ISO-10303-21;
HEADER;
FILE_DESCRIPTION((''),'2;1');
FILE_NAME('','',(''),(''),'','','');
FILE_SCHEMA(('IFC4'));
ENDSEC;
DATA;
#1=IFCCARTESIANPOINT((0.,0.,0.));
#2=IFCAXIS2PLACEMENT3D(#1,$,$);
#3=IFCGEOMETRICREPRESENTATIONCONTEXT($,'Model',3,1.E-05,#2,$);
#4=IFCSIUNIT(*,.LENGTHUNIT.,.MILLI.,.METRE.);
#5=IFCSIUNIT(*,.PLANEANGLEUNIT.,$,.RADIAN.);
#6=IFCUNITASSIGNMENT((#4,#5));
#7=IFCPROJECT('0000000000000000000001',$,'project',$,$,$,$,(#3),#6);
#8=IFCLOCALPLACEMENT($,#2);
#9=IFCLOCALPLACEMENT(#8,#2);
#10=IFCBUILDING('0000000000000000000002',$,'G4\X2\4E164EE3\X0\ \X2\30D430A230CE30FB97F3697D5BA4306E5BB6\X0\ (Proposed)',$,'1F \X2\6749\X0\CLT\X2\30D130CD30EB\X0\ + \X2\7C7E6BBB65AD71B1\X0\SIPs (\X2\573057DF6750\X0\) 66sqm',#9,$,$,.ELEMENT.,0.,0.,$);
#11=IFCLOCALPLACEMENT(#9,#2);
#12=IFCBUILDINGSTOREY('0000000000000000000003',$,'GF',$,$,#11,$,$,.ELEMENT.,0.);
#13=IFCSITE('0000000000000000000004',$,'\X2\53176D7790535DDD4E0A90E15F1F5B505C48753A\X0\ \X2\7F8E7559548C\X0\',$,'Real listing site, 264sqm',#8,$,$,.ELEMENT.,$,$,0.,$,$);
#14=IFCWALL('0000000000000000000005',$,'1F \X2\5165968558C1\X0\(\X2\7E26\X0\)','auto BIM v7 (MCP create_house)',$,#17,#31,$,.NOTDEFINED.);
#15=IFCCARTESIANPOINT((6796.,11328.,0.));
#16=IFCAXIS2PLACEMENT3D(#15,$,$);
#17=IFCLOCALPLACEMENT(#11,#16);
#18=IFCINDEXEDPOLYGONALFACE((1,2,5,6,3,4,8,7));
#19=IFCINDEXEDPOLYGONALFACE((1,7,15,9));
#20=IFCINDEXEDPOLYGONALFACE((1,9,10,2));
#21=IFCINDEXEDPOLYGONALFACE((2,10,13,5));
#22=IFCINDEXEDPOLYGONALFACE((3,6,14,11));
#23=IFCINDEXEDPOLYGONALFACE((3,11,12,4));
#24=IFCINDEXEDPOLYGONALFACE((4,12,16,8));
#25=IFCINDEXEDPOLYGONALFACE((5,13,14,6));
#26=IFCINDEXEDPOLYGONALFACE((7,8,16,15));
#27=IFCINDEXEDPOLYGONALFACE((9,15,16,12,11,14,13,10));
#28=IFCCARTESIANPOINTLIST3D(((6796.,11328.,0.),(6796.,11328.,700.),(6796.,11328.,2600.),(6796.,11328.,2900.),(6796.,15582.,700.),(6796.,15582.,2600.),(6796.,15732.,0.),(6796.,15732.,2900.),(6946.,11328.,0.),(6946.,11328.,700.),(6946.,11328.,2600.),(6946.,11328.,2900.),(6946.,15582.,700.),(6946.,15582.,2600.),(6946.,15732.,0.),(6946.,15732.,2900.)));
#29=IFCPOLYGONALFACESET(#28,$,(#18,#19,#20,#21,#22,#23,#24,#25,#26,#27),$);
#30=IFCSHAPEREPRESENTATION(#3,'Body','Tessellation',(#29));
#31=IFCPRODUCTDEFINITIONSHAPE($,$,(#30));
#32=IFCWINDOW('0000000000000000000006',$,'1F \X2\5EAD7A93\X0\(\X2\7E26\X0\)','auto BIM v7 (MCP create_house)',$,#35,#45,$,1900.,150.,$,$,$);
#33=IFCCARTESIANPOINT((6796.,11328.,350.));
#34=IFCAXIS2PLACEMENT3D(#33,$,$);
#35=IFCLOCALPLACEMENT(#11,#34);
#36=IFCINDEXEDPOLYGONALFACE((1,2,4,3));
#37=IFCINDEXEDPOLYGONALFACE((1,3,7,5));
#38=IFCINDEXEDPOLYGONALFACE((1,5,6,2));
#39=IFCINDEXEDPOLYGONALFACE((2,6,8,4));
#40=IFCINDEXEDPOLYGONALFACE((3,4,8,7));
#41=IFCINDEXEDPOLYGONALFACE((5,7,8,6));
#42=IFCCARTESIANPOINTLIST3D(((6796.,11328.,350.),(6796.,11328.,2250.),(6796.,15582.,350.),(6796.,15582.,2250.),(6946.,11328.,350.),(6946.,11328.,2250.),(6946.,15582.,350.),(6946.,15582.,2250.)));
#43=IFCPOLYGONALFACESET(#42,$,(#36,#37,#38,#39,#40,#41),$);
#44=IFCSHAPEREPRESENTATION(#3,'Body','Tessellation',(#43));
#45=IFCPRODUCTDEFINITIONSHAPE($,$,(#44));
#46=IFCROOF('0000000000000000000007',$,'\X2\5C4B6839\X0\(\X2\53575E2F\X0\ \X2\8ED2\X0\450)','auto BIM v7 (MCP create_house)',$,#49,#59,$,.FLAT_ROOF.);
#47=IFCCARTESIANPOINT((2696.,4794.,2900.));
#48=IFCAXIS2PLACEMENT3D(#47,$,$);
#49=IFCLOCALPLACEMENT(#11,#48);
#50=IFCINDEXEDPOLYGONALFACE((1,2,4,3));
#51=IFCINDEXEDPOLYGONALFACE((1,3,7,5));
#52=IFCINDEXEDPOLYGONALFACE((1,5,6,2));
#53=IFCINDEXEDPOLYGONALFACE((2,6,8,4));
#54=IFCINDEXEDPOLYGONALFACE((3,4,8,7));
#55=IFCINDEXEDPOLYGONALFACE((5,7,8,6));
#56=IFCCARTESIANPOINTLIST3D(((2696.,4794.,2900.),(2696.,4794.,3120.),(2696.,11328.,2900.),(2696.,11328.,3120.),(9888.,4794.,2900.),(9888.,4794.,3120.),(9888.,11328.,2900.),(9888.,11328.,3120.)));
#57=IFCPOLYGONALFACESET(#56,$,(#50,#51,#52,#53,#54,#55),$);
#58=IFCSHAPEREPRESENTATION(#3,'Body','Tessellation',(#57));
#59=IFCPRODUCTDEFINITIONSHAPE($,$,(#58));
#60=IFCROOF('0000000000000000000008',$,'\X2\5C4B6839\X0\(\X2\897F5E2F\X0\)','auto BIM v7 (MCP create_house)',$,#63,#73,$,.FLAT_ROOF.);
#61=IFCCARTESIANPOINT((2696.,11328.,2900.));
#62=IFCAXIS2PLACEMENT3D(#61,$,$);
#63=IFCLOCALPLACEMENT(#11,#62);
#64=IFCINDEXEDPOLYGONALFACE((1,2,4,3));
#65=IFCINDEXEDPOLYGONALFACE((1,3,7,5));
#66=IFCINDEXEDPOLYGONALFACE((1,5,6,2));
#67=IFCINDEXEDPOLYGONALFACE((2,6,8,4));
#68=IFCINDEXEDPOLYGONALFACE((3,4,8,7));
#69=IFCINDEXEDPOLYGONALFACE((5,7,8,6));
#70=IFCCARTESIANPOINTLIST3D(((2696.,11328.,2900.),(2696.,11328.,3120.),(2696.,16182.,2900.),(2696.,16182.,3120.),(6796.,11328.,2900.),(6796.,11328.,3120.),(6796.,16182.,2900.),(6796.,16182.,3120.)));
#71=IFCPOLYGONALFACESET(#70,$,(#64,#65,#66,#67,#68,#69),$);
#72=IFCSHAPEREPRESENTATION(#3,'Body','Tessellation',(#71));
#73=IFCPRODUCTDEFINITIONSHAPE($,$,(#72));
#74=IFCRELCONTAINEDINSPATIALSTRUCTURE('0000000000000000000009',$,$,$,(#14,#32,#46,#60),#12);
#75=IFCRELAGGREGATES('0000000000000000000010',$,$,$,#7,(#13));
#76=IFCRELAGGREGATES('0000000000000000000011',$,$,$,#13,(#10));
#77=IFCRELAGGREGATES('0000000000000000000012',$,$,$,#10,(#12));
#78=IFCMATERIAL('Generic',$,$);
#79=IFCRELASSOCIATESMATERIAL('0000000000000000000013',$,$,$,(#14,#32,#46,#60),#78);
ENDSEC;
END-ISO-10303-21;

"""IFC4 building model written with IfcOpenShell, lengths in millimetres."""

from ifc_helpers import new_model, si_unit, frame, frame_2d, origin, place, context, project, spatial, rectangle, extrude, material, element, fill, save


model = new_model("IFC4")

# Units and contexts
model_context = context("Model", 3, precision=1e-05, world=origin())
ifc_project = project(units=[si_unit("LENGTHUNIT", "METRE", prefix="MILLI"), si_unit("PLANEANGLEUNIT", "RADIAN")], contexts=[model_context])

# Site, building, storey
site_placement = place(None, origin())
site = spatial("IfcSite", under=ifc_project, at=site_placement, Name="北海道川上郡弟子屈町 美留和", ObjectType="Real listing site, 264sqm", CompositionType="ELEMENT", RefElevation=0.0)
building_placement = place(site_placement, origin())
building = spatial("IfcBuilding", under=site, at=building_placement, Name="G4世代 ピアノ・音楽室の家 (Proposed)", ObjectType="1F 杉CLTパネル + 籾殻断熱SIPs (地域材) 66sqm", CompositionType="ELEMENT", ElevationOfRefHeight=0.0, ElevationOfTerrain=0.0)
storey_placement = place(building_placement, origin())
storey = spatial("IfcBuildingStorey", under=building, at=storey_placement, Name="GF", CompositionType="ELEMENT", Elevation=0.0)

# Shared definitions
ifc_material = material(Name="Generic")

# Wall, opening, window
wall_1_placement = place(storey_placement, frame((6796.0, 11328.0, 0.0)))
wall_1 = element("IfcWall", 1, at=wall_1_placement, inside=storey, material=ifc_material, Name="1F 入隅壁(縦)", Description="auto BIM v7 (MCP create_house)", PredefinedType="NOTDEFINED", context=model_context, shape_type="SweptSolid", body=[
    extrude(rectangle(XDim=150.0, YDim=4404.0, at=frame_2d((75.0, 2202.0))), frame((6796.0, 11328.0, 0.0)), (0.0, 0.0, 1.0), 2900.0),
])
opening_1_placement = place(storey_placement, frame((6796.0, 11328.0, 350.0)))
opening_1 = element("IfcOpeningElement", 2, at=opening_1_placement, cuts=wall_1, PredefinedType="NOTDEFINED", context=model_context, shape_type="SweptSolid", body=[
    extrude(rectangle(XDim=150.0, YDim=4254.0, at=frame_2d((75.0, 2127.0))), frame((6796.0, 11328.0, 350.0)), (0.0, 0.0, 1.0), 1900.0),
])
window_1_placement = place(storey_placement, frame((6796.0, 11328.0, 350.0)))
window_1 = element("IfcWindow", 3, at=window_1_placement, inside=storey, material=ifc_material, Name="1F 庭窓(縦)", Description="auto BIM v7 (MCP create_house)", OverallHeight=1900.0, OverallWidth=150.0, context=model_context, shape_type="SweptSolid", body=[
    extrude(rectangle(XDim=150.0, YDim=4254.0, at=frame_2d((75.0, 2127.0))), frame((6796.0, 11328.0, 350.0)), (0.0, 0.0, 1.0), 1900.0),
])
fill(opening_1, window_1)

# Roofs
roof_1_placement = place(storey_placement, frame((2696.0, 4794.0, 2900.0)))
element("IfcRoof", 4, at=roof_1_placement, inside=storey, material=ifc_material, Name="屋根(南帯 軒450)", Description="auto BIM v7 (MCP create_house)", PredefinedType="FLAT_ROOF", context=model_context, shape_type="SweptSolid", body=[
    extrude(rectangle(XDim=7192.0, YDim=6534.0, at=frame_2d((3596.0, 3267.0))), frame((2696.0, 4794.0, 2900.0)), (0.0, 0.0, 1.0), 220.0),
])
roof_2_placement = place(storey_placement, frame((2696.0, 11328.0, 2900.0)))
element("IfcRoof", 5, at=roof_2_placement, inside=storey, material=ifc_material, Name="屋根(西帯)", Description="auto BIM v7 (MCP create_house)", PredefinedType="FLAT_ROOF", context=model_context, shape_type="SweptSolid", body=[
    extrude(rectangle(XDim=4100.0, YDim=4854.0, at=frame_2d((2050.0, 2427.0))), frame((2696.0, 11328.0, 2900.0)), (0.0, 0.0, 1.0), 220.0),
])

save(model, "model.ifc")
